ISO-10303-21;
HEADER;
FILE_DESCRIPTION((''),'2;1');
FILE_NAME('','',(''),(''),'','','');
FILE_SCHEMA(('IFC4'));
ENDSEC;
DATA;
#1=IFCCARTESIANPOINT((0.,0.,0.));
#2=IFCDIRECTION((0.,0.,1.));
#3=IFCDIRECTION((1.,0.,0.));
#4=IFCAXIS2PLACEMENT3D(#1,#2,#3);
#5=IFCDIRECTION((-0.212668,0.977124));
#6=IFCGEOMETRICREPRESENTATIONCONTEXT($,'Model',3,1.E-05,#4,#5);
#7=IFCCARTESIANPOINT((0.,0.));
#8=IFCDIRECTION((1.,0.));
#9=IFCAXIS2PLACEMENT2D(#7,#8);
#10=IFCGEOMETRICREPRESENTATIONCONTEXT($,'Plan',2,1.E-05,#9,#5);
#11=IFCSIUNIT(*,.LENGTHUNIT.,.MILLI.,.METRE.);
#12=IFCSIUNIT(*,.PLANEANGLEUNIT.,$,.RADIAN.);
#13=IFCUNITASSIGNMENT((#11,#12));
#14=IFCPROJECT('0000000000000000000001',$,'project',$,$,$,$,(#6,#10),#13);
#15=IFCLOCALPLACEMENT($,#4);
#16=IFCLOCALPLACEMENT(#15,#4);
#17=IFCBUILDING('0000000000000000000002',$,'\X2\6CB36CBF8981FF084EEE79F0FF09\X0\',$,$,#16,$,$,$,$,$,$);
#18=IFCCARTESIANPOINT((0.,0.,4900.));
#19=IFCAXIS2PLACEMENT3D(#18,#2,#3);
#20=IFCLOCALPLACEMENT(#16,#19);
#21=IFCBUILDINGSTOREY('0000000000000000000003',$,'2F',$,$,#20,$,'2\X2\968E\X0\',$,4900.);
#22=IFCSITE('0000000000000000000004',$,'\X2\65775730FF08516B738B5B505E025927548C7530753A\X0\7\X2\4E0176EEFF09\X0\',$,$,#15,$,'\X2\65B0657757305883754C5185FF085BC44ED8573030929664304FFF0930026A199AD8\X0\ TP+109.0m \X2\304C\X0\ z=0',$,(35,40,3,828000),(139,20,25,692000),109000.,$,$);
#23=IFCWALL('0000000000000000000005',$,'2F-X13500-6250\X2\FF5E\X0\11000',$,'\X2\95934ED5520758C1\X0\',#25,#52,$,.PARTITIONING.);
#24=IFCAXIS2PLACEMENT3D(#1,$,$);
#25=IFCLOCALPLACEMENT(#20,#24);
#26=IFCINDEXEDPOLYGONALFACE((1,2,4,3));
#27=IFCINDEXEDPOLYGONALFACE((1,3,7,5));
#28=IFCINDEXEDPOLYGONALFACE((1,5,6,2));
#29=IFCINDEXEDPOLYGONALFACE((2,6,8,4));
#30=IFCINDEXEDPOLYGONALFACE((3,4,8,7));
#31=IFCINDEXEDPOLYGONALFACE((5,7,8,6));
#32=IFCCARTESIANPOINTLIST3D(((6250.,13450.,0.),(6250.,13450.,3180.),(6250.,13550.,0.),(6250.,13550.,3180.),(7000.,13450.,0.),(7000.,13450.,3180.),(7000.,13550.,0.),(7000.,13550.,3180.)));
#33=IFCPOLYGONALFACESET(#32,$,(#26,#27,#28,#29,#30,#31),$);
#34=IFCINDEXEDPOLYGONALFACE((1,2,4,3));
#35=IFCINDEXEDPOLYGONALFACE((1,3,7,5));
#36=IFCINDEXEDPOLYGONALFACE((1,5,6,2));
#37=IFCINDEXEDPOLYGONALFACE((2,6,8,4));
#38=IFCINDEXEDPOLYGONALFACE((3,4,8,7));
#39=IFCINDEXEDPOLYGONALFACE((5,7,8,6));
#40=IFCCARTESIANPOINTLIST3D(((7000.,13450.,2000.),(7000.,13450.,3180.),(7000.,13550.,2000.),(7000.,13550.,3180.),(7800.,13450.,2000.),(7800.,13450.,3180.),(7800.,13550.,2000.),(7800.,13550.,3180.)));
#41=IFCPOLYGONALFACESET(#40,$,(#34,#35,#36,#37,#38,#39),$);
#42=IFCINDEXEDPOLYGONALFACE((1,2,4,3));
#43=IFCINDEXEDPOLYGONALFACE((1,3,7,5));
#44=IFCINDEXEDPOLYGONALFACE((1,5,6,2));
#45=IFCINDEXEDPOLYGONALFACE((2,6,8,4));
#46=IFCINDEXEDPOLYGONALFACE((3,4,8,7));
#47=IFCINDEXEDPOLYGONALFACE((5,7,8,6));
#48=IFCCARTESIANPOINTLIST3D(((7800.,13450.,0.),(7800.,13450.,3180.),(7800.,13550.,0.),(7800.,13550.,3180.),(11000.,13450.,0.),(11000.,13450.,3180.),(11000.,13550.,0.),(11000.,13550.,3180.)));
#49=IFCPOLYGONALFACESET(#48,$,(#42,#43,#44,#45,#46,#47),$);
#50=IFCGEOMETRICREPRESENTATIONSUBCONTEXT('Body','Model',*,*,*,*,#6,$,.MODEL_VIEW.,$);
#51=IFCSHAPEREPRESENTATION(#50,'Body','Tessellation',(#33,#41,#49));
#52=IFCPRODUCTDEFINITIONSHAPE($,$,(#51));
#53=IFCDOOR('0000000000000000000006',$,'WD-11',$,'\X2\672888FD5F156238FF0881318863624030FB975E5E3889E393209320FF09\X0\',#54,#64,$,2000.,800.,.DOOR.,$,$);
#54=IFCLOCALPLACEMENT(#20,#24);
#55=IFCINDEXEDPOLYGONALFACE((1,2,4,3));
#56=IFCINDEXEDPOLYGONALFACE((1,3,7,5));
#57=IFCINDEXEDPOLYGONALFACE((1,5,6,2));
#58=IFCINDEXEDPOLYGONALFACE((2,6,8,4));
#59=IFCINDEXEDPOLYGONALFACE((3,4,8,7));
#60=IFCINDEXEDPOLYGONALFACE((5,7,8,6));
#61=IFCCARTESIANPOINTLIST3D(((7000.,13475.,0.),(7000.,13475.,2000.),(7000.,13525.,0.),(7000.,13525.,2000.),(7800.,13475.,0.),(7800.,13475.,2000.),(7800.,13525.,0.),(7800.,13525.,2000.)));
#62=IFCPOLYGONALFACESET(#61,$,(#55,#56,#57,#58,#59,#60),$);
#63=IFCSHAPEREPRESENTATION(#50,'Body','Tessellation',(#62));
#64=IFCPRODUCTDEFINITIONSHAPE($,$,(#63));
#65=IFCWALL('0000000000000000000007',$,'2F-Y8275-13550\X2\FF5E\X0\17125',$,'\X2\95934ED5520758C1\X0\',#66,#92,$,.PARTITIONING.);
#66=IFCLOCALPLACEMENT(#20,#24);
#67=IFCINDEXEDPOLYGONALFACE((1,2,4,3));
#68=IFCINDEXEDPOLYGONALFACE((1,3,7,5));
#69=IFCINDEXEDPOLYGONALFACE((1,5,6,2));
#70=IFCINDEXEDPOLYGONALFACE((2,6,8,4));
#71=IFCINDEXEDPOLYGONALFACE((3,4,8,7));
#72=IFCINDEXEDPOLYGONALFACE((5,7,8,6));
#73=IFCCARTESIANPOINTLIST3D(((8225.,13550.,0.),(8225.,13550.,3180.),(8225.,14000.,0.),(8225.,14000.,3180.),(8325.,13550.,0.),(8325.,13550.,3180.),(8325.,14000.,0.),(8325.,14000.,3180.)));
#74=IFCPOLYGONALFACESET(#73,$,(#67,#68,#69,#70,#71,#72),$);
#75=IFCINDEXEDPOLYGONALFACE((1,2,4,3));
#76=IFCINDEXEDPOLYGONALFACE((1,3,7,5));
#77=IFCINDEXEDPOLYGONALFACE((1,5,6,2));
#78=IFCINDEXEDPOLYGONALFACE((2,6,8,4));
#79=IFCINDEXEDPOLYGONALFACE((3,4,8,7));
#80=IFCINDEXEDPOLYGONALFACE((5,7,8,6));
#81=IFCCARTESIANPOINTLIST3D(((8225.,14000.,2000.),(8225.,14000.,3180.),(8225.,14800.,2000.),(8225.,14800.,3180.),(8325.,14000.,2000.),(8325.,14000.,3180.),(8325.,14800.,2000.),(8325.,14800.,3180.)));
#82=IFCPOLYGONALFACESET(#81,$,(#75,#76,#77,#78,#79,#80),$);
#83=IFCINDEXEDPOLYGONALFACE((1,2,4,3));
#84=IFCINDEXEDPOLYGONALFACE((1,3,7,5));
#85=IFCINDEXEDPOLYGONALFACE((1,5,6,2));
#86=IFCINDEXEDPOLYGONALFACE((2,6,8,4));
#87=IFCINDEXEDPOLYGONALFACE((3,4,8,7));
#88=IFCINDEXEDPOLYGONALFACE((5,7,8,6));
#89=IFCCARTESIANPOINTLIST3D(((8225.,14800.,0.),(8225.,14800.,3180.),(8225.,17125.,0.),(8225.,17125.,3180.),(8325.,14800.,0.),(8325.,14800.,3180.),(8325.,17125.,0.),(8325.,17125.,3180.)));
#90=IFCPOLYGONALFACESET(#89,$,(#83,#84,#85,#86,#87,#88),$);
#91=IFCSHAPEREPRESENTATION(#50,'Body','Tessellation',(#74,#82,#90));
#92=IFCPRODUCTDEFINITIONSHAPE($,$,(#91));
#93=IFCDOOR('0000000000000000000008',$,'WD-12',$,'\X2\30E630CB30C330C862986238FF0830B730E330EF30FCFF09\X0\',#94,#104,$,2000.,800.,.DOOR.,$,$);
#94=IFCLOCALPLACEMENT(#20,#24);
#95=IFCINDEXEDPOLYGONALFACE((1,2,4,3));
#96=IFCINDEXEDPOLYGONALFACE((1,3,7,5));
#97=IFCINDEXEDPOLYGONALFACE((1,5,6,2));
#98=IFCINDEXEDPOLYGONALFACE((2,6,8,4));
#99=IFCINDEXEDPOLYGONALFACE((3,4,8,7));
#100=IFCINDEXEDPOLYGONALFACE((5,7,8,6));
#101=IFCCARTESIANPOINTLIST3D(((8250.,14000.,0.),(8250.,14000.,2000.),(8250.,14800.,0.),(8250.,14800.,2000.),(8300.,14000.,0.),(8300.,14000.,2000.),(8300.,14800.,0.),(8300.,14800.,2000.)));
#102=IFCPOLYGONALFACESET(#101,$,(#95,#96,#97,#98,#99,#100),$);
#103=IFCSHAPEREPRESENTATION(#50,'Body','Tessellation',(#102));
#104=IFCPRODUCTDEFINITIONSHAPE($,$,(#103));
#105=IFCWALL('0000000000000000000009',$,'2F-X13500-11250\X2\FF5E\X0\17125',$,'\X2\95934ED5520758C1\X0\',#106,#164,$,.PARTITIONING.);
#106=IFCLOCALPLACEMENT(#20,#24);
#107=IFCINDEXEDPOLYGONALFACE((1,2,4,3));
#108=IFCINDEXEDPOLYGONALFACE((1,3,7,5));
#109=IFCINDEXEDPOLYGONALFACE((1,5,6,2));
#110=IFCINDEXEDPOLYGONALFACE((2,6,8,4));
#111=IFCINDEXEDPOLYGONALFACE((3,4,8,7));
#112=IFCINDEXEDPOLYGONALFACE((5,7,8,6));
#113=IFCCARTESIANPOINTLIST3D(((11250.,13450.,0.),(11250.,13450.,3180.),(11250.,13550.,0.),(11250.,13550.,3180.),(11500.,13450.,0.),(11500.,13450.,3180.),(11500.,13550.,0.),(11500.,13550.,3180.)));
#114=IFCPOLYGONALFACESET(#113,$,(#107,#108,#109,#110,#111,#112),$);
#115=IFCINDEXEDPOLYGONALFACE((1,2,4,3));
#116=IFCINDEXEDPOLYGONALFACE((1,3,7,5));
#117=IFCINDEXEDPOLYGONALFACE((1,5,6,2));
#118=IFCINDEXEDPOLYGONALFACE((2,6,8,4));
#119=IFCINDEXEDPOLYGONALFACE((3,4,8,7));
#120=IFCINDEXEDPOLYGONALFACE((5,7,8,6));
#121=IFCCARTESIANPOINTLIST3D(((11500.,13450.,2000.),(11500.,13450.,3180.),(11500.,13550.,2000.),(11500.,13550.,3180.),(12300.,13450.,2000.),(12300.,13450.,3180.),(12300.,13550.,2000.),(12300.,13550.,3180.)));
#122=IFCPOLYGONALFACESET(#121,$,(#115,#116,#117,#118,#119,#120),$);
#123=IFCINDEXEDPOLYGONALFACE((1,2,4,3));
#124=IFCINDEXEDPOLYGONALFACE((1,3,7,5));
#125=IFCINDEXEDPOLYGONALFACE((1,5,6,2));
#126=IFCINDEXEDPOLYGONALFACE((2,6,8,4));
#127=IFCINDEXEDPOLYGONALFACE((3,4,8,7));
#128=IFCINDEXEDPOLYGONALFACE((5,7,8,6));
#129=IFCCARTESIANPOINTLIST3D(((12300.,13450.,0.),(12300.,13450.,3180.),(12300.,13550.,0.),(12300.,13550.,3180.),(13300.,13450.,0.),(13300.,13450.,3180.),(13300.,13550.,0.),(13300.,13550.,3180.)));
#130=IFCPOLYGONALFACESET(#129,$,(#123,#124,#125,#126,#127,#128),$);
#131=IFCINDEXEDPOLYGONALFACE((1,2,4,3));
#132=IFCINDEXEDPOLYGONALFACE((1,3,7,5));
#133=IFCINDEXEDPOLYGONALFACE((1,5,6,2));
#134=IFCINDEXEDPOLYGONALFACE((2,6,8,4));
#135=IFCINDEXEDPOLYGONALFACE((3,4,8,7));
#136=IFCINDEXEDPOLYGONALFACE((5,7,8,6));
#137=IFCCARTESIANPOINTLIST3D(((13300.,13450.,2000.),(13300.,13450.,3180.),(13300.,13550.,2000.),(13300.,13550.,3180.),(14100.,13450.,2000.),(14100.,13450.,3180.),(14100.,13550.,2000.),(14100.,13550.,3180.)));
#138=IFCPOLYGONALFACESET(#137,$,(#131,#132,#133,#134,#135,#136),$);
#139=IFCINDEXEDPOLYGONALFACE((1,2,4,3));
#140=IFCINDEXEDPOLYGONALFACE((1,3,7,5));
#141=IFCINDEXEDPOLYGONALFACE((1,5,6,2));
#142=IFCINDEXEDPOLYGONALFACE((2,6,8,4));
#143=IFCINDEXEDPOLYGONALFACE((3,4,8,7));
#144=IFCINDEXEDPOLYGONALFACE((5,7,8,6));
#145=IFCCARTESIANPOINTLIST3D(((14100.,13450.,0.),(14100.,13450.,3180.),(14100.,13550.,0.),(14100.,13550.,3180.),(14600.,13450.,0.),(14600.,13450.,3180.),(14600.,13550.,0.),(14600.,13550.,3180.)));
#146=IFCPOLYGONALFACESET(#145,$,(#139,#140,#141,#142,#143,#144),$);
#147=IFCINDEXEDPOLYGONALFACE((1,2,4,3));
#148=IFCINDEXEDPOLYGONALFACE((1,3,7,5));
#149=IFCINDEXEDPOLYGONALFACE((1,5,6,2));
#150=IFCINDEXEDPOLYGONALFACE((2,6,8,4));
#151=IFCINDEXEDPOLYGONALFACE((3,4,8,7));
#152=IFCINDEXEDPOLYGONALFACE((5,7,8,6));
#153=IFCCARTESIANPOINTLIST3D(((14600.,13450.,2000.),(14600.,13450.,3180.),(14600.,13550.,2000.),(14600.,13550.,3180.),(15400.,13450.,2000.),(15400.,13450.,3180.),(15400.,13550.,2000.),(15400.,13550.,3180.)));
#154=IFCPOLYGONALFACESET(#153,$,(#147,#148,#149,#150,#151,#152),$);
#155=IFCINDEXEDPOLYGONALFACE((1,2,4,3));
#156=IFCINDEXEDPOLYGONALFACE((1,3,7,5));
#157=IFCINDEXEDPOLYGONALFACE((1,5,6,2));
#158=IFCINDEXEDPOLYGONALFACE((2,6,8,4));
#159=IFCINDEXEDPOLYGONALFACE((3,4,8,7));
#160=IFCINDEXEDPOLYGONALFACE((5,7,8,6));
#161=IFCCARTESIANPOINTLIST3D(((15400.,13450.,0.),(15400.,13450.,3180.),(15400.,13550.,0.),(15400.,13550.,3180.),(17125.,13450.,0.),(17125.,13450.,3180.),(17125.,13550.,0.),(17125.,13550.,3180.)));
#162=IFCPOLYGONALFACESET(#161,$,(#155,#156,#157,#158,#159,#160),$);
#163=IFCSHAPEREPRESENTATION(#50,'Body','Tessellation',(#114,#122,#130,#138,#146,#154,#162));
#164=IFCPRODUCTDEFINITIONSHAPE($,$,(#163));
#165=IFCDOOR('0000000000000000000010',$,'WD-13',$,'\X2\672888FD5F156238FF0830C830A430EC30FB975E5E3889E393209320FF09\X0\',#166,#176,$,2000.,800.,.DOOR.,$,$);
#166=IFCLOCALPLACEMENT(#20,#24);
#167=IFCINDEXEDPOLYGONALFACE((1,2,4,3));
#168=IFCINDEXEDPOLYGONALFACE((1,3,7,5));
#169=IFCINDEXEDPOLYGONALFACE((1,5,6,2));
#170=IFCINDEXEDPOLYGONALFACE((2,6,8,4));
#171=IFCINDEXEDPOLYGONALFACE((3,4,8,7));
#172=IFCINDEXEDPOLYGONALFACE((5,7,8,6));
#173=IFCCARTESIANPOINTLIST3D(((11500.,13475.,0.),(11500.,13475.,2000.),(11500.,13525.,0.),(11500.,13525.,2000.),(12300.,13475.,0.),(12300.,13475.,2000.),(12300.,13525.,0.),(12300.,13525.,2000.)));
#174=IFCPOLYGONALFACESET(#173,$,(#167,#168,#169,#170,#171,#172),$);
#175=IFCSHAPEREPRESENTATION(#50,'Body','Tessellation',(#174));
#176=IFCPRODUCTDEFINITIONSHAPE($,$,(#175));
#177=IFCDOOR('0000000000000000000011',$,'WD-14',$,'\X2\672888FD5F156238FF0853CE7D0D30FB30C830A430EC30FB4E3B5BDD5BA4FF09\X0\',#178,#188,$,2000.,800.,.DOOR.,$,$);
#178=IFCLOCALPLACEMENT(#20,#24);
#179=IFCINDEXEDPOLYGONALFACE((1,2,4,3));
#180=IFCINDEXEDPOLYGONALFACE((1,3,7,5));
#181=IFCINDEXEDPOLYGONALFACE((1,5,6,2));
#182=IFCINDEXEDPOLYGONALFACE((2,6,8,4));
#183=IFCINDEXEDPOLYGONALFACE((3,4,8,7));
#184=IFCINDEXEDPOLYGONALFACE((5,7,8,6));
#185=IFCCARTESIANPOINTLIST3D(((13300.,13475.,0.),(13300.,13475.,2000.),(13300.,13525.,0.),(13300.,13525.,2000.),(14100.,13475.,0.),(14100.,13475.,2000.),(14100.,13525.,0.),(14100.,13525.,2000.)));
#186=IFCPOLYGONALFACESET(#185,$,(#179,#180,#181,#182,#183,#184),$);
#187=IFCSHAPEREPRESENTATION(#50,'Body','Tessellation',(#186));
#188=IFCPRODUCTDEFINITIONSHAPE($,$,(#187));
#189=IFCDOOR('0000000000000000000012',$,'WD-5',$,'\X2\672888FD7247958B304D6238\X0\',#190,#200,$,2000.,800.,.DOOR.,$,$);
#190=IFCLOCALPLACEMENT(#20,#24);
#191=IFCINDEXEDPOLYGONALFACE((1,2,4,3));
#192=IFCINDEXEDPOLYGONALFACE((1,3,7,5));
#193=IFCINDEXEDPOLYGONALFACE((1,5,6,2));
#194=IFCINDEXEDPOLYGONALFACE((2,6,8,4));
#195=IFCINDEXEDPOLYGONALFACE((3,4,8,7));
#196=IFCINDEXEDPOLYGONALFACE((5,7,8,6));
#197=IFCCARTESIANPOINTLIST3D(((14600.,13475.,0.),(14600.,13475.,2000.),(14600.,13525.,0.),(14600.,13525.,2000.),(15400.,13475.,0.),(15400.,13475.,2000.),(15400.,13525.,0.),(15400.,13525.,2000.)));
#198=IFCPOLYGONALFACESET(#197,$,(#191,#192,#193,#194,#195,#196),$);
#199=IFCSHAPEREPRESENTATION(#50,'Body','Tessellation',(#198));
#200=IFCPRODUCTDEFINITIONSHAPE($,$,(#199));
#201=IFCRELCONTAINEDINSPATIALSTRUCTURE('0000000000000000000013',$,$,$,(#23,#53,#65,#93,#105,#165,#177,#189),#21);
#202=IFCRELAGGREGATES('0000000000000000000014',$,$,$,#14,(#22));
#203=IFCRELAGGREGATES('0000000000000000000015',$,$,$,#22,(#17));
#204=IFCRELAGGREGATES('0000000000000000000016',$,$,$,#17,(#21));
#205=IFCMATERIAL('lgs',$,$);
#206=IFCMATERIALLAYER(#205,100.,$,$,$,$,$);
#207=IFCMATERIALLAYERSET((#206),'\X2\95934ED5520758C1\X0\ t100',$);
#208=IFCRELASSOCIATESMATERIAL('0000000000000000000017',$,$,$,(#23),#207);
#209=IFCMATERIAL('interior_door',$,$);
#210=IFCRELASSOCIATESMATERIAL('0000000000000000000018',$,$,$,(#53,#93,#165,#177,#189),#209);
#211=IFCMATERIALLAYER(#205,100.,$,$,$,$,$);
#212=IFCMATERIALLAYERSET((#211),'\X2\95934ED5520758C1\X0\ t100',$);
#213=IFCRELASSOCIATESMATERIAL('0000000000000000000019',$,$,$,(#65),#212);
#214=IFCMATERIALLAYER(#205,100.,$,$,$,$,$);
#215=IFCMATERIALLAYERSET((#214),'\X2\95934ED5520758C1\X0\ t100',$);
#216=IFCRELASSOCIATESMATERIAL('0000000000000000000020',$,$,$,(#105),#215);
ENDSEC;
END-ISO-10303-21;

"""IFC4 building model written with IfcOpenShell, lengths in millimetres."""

from ifc_helpers import new_model, si_unit, direction, frame, frame_2d, origin, origin_with_axes, origin_2d_with_axis, place, context, subcontext, project, spatial, rectangle, extrude, material, layer, layer_set, layer_usage, element, fill, save


model = new_model("IFC4")

# Units and contexts
model_context = context("Model", 3, precision=1e-05, world=origin_with_axes(), true_north=direction((-0.212668, 0.977124)))
plan_context = context("Plan", 2, precision=1e-05, world=origin_2d_with_axis(), true_north=direction((-0.212668, 0.977124)))
body_context = subcontext(model_context, "Body", "Model", "MODEL_VIEW")
ifc_project = project(units=[si_unit("LENGTHUNIT", "METRE", prefix="MILLI"), si_unit("PLANEANGLEUNIT", "RADIAN")], contexts=[model_context, plan_context])

# Site, building, storey
site_placement = place(None, origin_with_axes())
site = spatial("IfcSite", under=ifc_project, at=site_placement, Name="敷地（八王子市大和田町7丁目）", LongName="新敷地境界内（寄付地を除く）。標高 TP+109.0m が z=0", RefLatitude=(35, 40, 3, 828000), RefLongitude=(139, 20, 25, 692000), RefElevation=109000.0)
building_placement = place(site_placement, origin_with_axes())
building = spatial("IfcBuilding", under=site, at=building_placement, Name="河沿要（仮称）")
storey_placement = place(building_placement, frame((0.0, 0.0, 4900.0), z_axis=(0.0, 0.0, 1.0), x_axis=(1.0, 0.0, 0.0)))
storey = spatial("IfcBuildingStorey", under=building, at=storey_placement, Name="2F", LongName="2階", Elevation=4900.0)

# Shared definitions
ifc_material_1 = material(Name="lgs")

# Walls, openings, doors
ifc_material_2 = material(Name="interior_door")
ifc_layer_1 = layer(ifc_material_1, 100.0)
ifc_layer_set_1 = layer_set([ifc_layer_1], Name="間仕切壁 t100")
ifc_layer_usage_1 = layer_usage(ifc_layer_set_1, "AXIS2", "POSITIVE", 0.0)
wall_1_placement = place(storey_placement, origin_with_axes())
wall_1 = element("IfcWall", 1, at=wall_1_placement, inside=storey, material=ifc_layer_usage_1, Name="2F-X13500-6250～11000", ObjectType="間仕切壁", PredefinedType="PARTITIONING", context=body_context, shape_type="SweptSolid", body=[
    extrude(rectangle(XDim=750.0, YDim=100.0, at=frame_2d((6625.0, 13500.0))), origin(), (0.0, 0.0, 1.0), 3180.0),
    extrude(rectangle(XDim=800.0, YDim=100.0, at=frame_2d((7400.0, 13500.0))), frame((0.0, 0.0, 2000.0)), (0.0, 0.0, 1.0), 1180.0),
    extrude(rectangle(XDim=3200.0, YDim=100.0, at=frame_2d((9400.0, 13500.0))), origin(), (0.0, 0.0, 1.0), 3180.0),
])
opening_1_placement = place(storey_placement, origin_with_axes())
opening_1 = element("IfcOpeningElement", 2, at=opening_1_placement, inside=storey, cuts=wall_1, PredefinedType="OPENING", context=body_context, shape_type="SweptSolid", body=[
    extrude(rectangle(XDim=800.0, YDim=150.0, at=frame_2d((7400.0, 13500.0))), origin(), (0.0, 0.0, 1.0), 2000.0),
])
door_1_placement = place(storey_placement, origin_with_axes())
door_1 = element("IfcDoor", 3, at=door_1_placement, inside=storey, material=ifc_material_2, Name="WD-11", ObjectType="木製引戸（脱衣所・非常解錠錠）", OverallHeight=2000.0, OverallWidth=800.0, PredefinedType="DOOR", context=body_context, shape_type="SweptSolid", body=[
    extrude(rectangle(XDim=800.0, YDim=50.0, at=frame_2d((7400.0, 13500.0))), origin(), (0.0, 0.0, 1.0), 2000.0),
])
fill(opening_1, door_1)
ifc_layer_2 = layer(ifc_material_1, 100.0)
ifc_layer_set_2 = layer_set([ifc_layer_2], Name="間仕切壁 t100")
ifc_layer_usage_2 = layer_usage(ifc_layer_set_2, "AXIS2", "POSITIVE", 0.0)
wall_2_placement = place(storey_placement, origin_with_axes())
wall_2 = element("IfcWall", 4, at=wall_2_placement, inside=storey, material=ifc_layer_usage_2, Name="2F-Y8275-13550～17125", ObjectType="間仕切壁", PredefinedType="PARTITIONING", context=body_context, shape_type="SweptSolid", body=[
    extrude(rectangle(XDim=100.0, YDim=450.0, at=frame_2d((8275.0, 13775.0))), origin(), (0.0, 0.0, 1.0), 3180.0),
    extrude(rectangle(XDim=100.0, YDim=800.0, at=frame_2d((8275.0, 14400.0))), frame((0.0, 0.0, 2000.0)), (0.0, 0.0, 1.0), 1180.0),
    extrude(rectangle(XDim=100.0, YDim=2325.0, at=frame_2d((8275.0, 15962.5))), origin(), (0.0, 0.0, 1.0), 3180.0),
])
opening_2_placement = place(storey_placement, origin_with_axes())
opening_2 = element("IfcOpeningElement", 5, at=opening_2_placement, inside=storey, cuts=wall_2, PredefinedType="OPENING", context=body_context, shape_type="SweptSolid", body=[
    extrude(rectangle(XDim=150.0, YDim=800.0, at=frame_2d((8275.0, 14400.0))), origin(), (0.0, 0.0, 1.0), 2000.0),
])
door_2_placement = place(storey_placement, origin_with_axes())
door_2 = element("IfcDoor", 6, at=door_2_placement, inside=storey, material=ifc_material_2, Name="WD-12", ObjectType="ユニット折戸（シャワー）", OverallHeight=2000.0, OverallWidth=800.0, PredefinedType="DOOR", context=body_context, shape_type="SweptSolid", body=[
    extrude(rectangle(XDim=50.0, YDim=800.0, at=frame_2d((8275.0, 14400.0))), origin(), (0.0, 0.0, 1.0), 2000.0),
])
fill(opening_2, door_2)

# Wall, openings, doors
ifc_layer_3 = layer(ifc_material_1, 100.0)
ifc_layer_set_3 = layer_set([ifc_layer_3], Name="間仕切壁 t100")
ifc_layer_usage_3 = layer_usage(ifc_layer_set_3, "AXIS2", "POSITIVE", 0.0)
wall_3_placement = place(storey_placement, origin_with_axes())
wall_3 = element("IfcWall", 7, at=wall_3_placement, inside=storey, material=ifc_layer_usage_3, Name="2F-X13500-11250～17125", ObjectType="間仕切壁", PredefinedType="PARTITIONING", context=body_context, shape_type="SweptSolid", body=[
    extrude(rectangle(XDim=250.0, YDim=100.0, at=frame_2d((11375.0, 13500.0))), origin(), (0.0, 0.0, 1.0), 3180.0),
    extrude(rectangle(XDim=800.0, YDim=100.0, at=frame_2d((11900.0, 13500.0))), frame((0.0, 0.0, 2000.0)), (0.0, 0.0, 1.0), 1180.0),
    extrude(rectangle(XDim=1000.0, YDim=100.0, at=frame_2d((12800.0, 13500.0))), origin(), (0.0, 0.0, 1.0), 3180.0),
    extrude(rectangle(XDim=800.0, YDim=100.0, at=frame_2d((13700.0, 13500.0))), frame((0.0, 0.0, 2000.0)), (0.0, 0.0, 1.0), 1180.0),
    extrude(rectangle(XDim=500.0, YDim=100.0, at=frame_2d((14350.0, 13500.0))), origin(), (0.0, 0.0, 1.0), 3180.0),
    extrude(rectangle(XDim=800.0, YDim=100.0, at=frame_2d((15000.0, 13500.0))), frame((0.0, 0.0, 2000.0)), (0.0, 0.0, 1.0), 1180.0),
    extrude(rectangle(XDim=1725.0, YDim=100.0, at=frame_2d((16262.5, 13500.0))), origin(), (0.0, 0.0, 1.0), 3180.0),
])
opening_3_placement = place(storey_placement, origin_with_axes())
opening_3 = element("IfcOpeningElement", 8, at=opening_3_placement, inside=storey, cuts=wall_3, PredefinedType="OPENING", context=body_context, shape_type="SweptSolid", body=[
    extrude(rectangle(XDim=800.0, YDim=150.0, at=frame_2d((11900.0, 13500.0))), origin(), (0.0, 0.0, 1.0), 2000.0),
])
opening_4_placement = place(storey_placement, origin_with_axes())
opening_4 = element("IfcOpeningElement", 9, at=opening_4_placement, inside=storey, cuts=wall_3, PredefinedType="OPENING", context=body_context, shape_type="SweptSolid", body=[
    extrude(rectangle(XDim=800.0, YDim=150.0, at=frame_2d((13700.0, 13500.0))), origin(), (0.0, 0.0, 1.0), 2000.0),
])
opening_5_placement = place(storey_placement, origin_with_axes())
opening_5 = element("IfcOpeningElement", 10, at=opening_5_placement, inside=storey, cuts=wall_3, PredefinedType="OPENING", context=body_context, shape_type="SweptSolid", body=[
    extrude(rectangle(XDim=800.0, YDim=150.0, at=frame_2d((15000.0, 13500.0))), origin(), (0.0, 0.0, 1.0), 2000.0),
])
door_3_placement = place(storey_placement, origin_with_axes())
door_3 = element("IfcDoor", 11, at=door_3_placement, inside=storey, material=ifc_material_2, Name="WD-13", ObjectType="木製引戸（トイレ・非常解錠錠）", OverallHeight=2000.0, OverallWidth=800.0, PredefinedType="DOOR", context=body_context, shape_type="SweptSolid", body=[
    extrude(rectangle(XDim=800.0, YDim=50.0, at=frame_2d((11900.0, 13500.0))), origin(), (0.0, 0.0, 1.0), 2000.0),
])
fill(opening_3, door_3)
door_4_placement = place(storey_placement, origin_with_axes())
door_4 = element("IfcDoor", 12, at=door_4_placement, inside=storey, material=ifc_material_2, Name="WD-14", ObjectType="木製引戸（収納・トイレ・主寝室）", OverallHeight=2000.0, OverallWidth=800.0, PredefinedType="DOOR", context=body_context, shape_type="SweptSolid", body=[
    extrude(rectangle(XDim=800.0, YDim=50.0, at=frame_2d((13700.0, 13500.0))), origin(), (0.0, 0.0, 1.0), 2000.0),
])
fill(opening_4, door_4)
door_5_placement = place(storey_placement, origin_with_axes())
door_5 = element("IfcDoor", 13, at=door_5_placement, inside=storey, material=ifc_material_2, Name="WD-5", ObjectType="木製片開き戸", OverallHeight=2000.0, OverallWidth=800.0, PredefinedType="DOOR", context=body_context, shape_type="SweptSolid", body=[
    extrude(rectangle(XDim=800.0, YDim=50.0, at=frame_2d((15000.0, 13500.0))), origin(), (0.0, 0.0, 1.0), 2000.0),
])
fill(opening_5, door_5)

save(model, "model.ifc")
